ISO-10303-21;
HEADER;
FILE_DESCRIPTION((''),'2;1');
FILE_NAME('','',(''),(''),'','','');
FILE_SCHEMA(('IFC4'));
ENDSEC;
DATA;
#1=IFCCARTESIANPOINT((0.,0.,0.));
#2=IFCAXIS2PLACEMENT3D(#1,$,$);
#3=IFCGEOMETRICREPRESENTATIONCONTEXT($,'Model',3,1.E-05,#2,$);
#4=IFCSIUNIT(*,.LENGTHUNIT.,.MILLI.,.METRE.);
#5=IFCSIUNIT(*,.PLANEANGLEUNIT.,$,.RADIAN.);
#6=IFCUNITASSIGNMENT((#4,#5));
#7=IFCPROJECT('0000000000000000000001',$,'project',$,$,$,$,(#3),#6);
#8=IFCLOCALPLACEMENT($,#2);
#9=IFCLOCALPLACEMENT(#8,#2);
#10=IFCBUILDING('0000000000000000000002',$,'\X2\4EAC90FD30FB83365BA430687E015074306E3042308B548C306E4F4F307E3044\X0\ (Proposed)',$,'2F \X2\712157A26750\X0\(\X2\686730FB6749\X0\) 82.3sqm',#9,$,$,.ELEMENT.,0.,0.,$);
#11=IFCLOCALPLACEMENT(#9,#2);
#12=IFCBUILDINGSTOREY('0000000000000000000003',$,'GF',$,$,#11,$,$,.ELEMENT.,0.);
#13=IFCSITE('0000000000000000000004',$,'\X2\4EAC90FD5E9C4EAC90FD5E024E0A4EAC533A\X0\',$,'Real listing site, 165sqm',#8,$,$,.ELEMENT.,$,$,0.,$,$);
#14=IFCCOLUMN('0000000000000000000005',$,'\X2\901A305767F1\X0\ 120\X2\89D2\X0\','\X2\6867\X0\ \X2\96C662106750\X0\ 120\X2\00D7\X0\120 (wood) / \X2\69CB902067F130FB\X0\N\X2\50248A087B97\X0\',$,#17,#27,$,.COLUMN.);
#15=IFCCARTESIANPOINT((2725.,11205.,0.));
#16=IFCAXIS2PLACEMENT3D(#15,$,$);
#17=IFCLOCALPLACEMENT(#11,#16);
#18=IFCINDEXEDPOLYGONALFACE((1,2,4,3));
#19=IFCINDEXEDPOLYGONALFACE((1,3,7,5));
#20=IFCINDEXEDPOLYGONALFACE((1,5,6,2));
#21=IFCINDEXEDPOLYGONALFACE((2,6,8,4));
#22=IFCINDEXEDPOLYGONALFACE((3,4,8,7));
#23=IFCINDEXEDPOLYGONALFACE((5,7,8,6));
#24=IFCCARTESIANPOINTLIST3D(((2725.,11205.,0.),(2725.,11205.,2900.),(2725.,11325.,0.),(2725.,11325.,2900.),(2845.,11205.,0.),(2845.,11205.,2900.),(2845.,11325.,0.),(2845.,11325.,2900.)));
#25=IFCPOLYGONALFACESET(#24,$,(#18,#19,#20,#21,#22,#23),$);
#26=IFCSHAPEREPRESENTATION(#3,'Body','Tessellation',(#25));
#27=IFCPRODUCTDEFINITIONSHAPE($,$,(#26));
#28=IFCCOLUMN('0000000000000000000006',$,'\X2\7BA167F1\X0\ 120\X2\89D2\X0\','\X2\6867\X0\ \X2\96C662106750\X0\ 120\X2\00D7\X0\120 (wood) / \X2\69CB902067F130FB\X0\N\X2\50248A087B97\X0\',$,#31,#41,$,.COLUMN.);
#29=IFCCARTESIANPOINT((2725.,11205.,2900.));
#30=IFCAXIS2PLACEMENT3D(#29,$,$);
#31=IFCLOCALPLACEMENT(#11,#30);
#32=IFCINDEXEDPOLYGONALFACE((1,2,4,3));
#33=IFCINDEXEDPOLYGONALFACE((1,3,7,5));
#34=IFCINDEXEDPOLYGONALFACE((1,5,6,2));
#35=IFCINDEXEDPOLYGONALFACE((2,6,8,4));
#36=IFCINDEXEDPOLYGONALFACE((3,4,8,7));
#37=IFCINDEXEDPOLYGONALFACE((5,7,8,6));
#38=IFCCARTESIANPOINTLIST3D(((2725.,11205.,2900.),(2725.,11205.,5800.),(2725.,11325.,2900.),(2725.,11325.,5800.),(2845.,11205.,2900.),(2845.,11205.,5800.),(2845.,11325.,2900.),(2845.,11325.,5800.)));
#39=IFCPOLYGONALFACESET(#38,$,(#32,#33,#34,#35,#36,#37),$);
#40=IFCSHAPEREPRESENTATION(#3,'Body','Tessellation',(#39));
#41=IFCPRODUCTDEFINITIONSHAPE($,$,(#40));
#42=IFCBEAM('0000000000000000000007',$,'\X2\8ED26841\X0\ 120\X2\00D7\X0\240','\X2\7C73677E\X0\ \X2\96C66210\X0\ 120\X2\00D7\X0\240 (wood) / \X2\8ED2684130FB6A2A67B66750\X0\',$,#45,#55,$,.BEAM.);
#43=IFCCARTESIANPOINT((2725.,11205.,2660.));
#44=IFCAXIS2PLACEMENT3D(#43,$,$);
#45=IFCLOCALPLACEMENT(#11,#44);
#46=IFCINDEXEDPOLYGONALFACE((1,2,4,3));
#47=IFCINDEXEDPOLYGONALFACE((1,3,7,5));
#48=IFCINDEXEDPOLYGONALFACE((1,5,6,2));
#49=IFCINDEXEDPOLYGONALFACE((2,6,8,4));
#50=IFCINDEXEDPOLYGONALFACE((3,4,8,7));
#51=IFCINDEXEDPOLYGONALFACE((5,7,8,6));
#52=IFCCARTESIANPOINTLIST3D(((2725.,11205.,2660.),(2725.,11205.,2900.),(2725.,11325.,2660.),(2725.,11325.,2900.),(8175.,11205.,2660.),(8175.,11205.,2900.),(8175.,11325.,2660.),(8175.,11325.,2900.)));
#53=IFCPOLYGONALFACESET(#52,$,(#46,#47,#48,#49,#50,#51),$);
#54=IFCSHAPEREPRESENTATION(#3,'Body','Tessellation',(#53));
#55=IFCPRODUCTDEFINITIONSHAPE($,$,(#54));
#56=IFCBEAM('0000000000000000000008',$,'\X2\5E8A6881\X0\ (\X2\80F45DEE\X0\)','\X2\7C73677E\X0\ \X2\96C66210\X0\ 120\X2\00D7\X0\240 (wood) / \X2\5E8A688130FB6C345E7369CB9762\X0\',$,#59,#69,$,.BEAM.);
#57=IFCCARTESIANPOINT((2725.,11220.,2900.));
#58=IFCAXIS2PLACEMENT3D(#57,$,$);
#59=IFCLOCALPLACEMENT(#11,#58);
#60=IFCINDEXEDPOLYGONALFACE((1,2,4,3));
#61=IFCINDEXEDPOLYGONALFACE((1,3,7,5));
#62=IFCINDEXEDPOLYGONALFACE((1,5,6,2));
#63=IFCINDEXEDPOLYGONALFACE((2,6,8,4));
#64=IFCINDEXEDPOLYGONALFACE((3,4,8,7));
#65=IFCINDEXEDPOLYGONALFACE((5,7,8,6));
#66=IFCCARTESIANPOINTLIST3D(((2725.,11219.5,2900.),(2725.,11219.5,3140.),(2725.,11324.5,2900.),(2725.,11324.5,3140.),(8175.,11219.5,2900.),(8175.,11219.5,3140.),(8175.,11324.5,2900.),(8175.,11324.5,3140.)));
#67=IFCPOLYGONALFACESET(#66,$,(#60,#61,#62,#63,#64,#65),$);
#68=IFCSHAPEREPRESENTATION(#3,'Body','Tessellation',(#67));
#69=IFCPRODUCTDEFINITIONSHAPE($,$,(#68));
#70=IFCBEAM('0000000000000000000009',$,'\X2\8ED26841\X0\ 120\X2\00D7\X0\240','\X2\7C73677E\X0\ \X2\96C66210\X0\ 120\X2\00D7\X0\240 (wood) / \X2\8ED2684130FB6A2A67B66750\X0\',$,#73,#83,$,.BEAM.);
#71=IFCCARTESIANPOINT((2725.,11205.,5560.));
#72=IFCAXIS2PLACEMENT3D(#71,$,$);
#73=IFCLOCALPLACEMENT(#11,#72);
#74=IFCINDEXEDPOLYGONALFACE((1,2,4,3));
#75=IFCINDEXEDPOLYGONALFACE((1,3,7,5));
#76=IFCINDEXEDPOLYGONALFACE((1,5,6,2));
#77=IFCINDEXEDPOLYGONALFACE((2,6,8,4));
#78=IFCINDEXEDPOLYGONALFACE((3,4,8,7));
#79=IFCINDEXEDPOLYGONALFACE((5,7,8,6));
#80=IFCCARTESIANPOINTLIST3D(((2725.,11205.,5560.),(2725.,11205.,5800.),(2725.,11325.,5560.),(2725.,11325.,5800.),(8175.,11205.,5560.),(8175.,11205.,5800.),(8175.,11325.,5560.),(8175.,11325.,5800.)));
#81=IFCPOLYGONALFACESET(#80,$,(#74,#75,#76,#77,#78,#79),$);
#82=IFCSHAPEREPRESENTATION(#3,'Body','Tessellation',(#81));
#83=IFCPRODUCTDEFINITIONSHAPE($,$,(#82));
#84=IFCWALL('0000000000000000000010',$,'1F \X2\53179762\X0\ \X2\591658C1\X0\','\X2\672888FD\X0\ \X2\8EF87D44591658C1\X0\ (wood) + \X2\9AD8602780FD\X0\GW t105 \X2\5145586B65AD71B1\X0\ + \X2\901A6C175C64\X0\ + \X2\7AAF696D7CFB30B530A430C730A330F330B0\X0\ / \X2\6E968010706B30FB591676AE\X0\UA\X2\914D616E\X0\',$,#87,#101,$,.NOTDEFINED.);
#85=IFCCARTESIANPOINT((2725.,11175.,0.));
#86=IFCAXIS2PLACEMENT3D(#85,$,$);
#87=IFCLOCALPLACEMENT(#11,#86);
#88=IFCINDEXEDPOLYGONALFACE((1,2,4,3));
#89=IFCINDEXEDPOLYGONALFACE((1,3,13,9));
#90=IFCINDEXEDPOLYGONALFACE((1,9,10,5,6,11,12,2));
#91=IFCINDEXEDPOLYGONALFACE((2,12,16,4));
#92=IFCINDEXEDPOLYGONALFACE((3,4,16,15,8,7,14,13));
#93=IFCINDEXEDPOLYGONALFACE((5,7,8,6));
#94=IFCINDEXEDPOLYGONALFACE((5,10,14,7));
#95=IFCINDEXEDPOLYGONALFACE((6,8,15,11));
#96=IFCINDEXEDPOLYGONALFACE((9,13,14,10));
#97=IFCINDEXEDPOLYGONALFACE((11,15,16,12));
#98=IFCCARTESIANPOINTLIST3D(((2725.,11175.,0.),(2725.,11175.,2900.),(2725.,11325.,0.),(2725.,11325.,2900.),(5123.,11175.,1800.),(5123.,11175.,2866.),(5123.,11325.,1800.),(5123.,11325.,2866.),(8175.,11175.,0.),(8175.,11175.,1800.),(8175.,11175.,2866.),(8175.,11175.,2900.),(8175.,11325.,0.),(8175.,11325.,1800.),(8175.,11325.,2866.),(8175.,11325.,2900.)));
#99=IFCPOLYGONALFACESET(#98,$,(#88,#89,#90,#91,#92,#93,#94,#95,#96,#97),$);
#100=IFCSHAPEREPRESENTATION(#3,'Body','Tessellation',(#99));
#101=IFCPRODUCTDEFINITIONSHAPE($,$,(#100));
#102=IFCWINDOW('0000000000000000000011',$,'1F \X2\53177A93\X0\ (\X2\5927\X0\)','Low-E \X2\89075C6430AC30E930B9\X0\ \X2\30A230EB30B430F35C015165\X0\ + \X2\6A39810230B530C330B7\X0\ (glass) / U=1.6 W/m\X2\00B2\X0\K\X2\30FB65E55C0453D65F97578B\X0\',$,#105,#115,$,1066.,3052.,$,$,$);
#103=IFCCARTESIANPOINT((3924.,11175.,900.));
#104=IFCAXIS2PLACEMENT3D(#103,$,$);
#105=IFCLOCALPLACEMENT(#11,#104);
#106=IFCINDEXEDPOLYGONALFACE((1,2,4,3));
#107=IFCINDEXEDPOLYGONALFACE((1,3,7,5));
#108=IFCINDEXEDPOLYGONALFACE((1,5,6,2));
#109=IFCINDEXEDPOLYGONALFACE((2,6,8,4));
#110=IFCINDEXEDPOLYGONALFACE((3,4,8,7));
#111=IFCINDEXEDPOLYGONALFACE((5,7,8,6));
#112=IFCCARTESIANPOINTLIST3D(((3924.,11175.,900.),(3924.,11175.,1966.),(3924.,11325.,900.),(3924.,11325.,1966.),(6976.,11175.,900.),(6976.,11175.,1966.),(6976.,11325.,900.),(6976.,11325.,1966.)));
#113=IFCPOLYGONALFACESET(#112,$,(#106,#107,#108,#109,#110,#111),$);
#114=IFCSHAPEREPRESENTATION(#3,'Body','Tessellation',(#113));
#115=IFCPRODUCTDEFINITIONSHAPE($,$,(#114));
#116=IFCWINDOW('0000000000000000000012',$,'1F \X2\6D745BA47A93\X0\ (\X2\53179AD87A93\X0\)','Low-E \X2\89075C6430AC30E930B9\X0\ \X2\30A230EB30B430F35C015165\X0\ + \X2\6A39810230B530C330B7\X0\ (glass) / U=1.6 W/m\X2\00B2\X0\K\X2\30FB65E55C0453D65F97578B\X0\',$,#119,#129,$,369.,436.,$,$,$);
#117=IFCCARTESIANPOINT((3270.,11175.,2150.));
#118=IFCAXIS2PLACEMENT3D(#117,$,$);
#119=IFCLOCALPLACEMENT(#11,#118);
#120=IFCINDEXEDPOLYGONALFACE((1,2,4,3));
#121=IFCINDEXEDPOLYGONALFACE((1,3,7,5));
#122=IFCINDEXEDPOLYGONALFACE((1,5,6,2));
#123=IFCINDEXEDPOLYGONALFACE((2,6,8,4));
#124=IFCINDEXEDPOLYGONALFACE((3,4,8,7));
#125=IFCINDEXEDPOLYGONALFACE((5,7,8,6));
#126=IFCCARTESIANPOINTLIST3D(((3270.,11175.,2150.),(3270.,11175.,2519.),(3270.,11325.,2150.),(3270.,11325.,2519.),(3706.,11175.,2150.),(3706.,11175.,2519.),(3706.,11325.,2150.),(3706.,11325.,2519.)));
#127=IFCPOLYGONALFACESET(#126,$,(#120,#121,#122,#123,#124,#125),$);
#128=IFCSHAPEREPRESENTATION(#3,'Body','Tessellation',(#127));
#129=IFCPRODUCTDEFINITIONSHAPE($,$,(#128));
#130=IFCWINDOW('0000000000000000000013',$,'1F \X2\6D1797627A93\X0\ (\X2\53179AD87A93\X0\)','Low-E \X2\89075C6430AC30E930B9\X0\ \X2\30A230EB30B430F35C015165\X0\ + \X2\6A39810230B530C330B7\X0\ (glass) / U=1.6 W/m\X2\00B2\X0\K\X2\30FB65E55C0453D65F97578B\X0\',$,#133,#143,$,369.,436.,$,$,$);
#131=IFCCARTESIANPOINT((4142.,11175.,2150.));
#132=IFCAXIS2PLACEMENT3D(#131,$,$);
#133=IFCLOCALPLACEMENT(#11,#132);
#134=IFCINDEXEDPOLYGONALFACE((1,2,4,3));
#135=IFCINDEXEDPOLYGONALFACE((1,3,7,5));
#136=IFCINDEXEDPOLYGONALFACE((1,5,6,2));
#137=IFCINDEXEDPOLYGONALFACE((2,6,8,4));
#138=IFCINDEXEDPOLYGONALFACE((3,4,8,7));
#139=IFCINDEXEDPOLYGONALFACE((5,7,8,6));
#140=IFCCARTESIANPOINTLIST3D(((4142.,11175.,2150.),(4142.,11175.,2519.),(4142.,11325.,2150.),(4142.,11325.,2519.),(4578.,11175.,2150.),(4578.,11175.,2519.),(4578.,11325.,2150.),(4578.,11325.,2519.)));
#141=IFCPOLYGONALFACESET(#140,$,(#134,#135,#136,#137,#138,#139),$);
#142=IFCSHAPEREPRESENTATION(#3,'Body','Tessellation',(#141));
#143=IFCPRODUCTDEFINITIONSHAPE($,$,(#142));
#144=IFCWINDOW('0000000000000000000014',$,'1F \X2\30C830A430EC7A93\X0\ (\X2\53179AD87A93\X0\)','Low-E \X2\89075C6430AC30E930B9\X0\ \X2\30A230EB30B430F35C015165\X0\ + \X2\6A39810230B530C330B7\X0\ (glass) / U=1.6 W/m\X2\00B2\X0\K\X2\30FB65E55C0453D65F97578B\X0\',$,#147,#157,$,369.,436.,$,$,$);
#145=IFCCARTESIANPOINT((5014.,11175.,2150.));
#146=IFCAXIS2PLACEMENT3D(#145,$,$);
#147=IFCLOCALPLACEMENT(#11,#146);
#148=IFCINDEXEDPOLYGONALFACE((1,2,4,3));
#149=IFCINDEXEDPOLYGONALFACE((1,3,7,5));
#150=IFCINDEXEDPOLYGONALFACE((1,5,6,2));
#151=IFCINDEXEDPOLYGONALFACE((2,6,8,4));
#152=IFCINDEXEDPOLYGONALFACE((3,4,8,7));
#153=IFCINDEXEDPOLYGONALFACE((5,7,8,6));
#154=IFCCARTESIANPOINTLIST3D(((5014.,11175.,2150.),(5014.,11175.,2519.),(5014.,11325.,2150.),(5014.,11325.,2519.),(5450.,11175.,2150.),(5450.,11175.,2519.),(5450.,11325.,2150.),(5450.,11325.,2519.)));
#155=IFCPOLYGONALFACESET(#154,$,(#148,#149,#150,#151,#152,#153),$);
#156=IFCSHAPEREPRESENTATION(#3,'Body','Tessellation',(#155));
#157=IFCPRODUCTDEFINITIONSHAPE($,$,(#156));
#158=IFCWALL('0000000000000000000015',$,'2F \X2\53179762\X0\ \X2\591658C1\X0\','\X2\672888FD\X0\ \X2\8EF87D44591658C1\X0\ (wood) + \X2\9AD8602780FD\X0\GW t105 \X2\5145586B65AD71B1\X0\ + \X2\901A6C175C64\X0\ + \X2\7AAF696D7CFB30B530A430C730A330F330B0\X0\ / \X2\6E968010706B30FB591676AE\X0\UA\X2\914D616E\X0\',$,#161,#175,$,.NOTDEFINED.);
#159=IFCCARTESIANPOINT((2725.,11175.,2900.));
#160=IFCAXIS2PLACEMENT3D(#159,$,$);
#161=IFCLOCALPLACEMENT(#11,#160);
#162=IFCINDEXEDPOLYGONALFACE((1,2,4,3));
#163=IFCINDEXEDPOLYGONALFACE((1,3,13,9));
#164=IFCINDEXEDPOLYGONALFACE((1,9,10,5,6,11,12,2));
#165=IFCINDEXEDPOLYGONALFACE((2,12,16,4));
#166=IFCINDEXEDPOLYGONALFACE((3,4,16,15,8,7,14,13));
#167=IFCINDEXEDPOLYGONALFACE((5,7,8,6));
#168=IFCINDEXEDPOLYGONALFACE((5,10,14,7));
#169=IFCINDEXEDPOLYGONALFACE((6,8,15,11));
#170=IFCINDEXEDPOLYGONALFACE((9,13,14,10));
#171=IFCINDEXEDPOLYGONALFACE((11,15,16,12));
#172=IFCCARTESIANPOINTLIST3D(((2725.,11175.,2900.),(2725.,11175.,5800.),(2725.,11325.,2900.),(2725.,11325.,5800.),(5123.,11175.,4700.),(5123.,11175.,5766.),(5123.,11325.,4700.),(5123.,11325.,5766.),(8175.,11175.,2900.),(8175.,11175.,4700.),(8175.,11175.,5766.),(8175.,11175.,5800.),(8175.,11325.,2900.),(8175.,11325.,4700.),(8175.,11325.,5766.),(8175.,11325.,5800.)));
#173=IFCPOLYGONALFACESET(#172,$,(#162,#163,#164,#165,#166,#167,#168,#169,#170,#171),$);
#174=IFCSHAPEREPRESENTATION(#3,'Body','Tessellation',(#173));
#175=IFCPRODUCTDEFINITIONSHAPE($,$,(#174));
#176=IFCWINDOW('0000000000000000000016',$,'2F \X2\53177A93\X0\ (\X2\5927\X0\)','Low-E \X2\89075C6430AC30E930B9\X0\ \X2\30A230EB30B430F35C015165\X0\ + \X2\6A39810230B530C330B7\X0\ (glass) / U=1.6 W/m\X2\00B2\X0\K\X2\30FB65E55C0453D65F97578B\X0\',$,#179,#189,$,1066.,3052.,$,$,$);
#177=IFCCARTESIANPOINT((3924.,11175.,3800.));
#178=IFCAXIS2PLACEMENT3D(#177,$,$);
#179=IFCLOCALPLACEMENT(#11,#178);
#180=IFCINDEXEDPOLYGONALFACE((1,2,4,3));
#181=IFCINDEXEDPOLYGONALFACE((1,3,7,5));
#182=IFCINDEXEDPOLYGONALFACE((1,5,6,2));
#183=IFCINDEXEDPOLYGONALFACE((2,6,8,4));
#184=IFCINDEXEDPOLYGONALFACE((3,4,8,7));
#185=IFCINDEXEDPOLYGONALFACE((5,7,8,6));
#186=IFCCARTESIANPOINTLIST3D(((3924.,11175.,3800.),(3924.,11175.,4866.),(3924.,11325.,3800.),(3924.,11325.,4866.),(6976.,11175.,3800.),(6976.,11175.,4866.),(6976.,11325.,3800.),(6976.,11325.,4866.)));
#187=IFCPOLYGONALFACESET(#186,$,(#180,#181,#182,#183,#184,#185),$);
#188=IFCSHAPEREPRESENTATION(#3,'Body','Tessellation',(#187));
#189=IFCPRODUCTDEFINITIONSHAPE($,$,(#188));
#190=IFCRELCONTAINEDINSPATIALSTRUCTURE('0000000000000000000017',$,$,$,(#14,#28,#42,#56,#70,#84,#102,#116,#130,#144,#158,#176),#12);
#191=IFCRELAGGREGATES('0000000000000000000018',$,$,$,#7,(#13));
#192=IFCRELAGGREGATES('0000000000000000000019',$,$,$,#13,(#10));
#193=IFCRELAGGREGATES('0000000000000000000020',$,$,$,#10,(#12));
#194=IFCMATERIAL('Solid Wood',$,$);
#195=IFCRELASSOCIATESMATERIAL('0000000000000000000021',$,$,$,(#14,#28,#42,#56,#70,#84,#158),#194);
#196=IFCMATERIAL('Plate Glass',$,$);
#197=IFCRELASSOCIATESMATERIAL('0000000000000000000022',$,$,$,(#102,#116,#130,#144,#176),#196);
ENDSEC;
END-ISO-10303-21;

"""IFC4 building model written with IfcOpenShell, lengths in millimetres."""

from ifc_helpers import new_model, si_unit, frame, frame_2d, origin, place, context, project, spatial, rectangle, extrude, material, element, fill, save


model = new_model("IFC4")

# Units and contexts
model_context = context("Model", 3, precision=1e-05, world=origin())
ifc_project = project(units=[si_unit("LENGTHUNIT", "METRE", prefix="MILLI"), si_unit("PLANEANGLEUNIT", "RADIAN")], contexts=[model_context])

# Site, building, storey
site_placement = place(None, origin())
site = spatial("IfcSite", under=ifc_project, at=site_placement, Name="京都府京都市上京区", ObjectType="Real listing site, 165sqm", CompositionType="ELEMENT", RefElevation=0.0)
building_placement = place(site_placement, origin())
building = spatial("IfcBuilding", under=site, at=building_placement, Name="京都・茶室と縁側のある和の住まい (Proposed)", ObjectType="2F 無垢材(桧・杉) 82.3sqm", CompositionType="ELEMENT", ElevationOfRefHeight=0.0, ElevationOfTerrain=0.0)
storey_placement = place(building_placement, origin())
storey = spatial("IfcBuildingStorey", under=building, at=storey_placement, Name="GF", CompositionType="ELEMENT", Elevation=0.0)

# Columns
ifc_material_1 = material(Name="Solid Wood")
column_1_placement = place(storey_placement, frame((2725.0, 11205.0, 0.0)))
element("IfcColumn", 1, at=column_1_placement, inside=storey, material=ifc_material_1, Name="通し柱 120角", Description="桧 集成材 120×120 (wood) / 構造柱・N値計算", PredefinedType="COLUMN", context=model_context, shape_type="SweptSolid", body=[
    extrude(rectangle(XDim=120.0, YDim=120.0, at=frame_2d((60.0, 60.0))), frame((2725.0, 11205.0, 0.0)), (0.0, 0.0, 1.0), 2900.0),
])
column_2_placement = place(storey_placement, frame((2725.0, 11205.0, 2900.0)))
element("IfcColumn", 2, at=column_2_placement, inside=storey, material=ifc_material_1, Name="管柱 120角", Description="桧 集成材 120×120 (wood) / 構造柱・N値計算", PredefinedType="COLUMN", context=model_context, shape_type="SweptSolid", body=[
    extrude(rectangle(XDim=120.0, YDim=120.0, at=frame_2d((60.0, 60.0))), frame((2725.0, 11205.0, 2900.0)), (0.0, 0.0, 1.0), 2900.0),
])

# Beams
beam_1_placement = place(storey_placement, frame((2725.0, 11205.0, 2660.0)))
element("IfcBeam", 3, at=beam_1_placement, inside=storey, material=ifc_material_1, Name="軒桁 120×240", Description="米松 集成 120×240 (wood) / 軒桁・横架材", PredefinedType="BEAM", context=model_context, shape_type="SweptSolid", body=[
    extrude(rectangle(XDim=5450.0, YDim=120.0, at=frame_2d((2725.0, 60.0))), frame((2725.0, 11205.0, 2660.0)), (0.0, 0.0, 1.0), 240.0),
])
beam_2_placement = place(storey_placement, frame((2725.0, 11220.0, 2900.0)))
element("IfcBeam", 4, at=beam_2_placement, inside=storey, material=ifc_material_1, Name="床梁 (胴差)", Description="米松 集成 120×240 (wood) / 床梁・水平構面", PredefinedType="BEAM", context=model_context, shape_type="SweptSolid", body=[
    extrude(rectangle(XDim=5450.0, YDim=105.0, at=frame_2d((2725.0, 52.0))), frame((2725.0, 11220.0, 2900.0)), (0.0, 0.0, 1.0), 240.0),
])
beam_3_placement = place(storey_placement, frame((2725.0, 11205.0, 5560.0)))
element("IfcBeam", 5, at=beam_3_placement, inside=storey, material=ifc_material_1, Name="軒桁 120×240", Description="米松 集成 120×240 (wood) / 軒桁・横架材", PredefinedType="BEAM", context=model_context, shape_type="SweptSolid", body=[
    extrude(rectangle(XDim=5450.0, YDim=120.0, at=frame_2d((2725.0, 60.0))), frame((2725.0, 11205.0, 5560.0)), (0.0, 0.0, 1.0), 240.0),
])

# Wall, openings, windows
wall_1_placement = place(storey_placement, frame((2725.0, 11175.0, 0.0)))
wall_1 = element("IfcWall", 6, at=wall_1_placement, inside=storey, material=ifc_material_1, Name="1F 北面 外壁", Description="木製 軸組外壁 (wood) + 高性能GW t105 充填断熱 + 通気層 + 窯業系サイディング / 準耐火・外皮UA配慮", PredefinedType="NOTDEFINED", context=model_context, shape_type="SweptSolid", body=[
    extrude(rectangle(XDim=5450.0, YDim=150.0, at=frame_2d((2725.0, 75.0))), frame((2725.0, 11175.0, 0.0)), (0.0, 0.0, 1.0), 2900.0),
])
opening_1_placement = place(storey_placement, frame((3924.0, 11175.0, 900.0)))
opening_1 = element("IfcOpeningElement", 7, at=opening_1_placement, cuts=wall_1, PredefinedType="NOTDEFINED", context=model_context, shape_type="SweptSolid", body=[
    extrude(rectangle(XDim=3052.0, YDim=150.0, at=frame_2d((1526.0, 75.0))), frame((3924.0, 11175.0, 900.0)), (0.0, 0.0, 1.0), 1066.0),
])
opening_2_placement = place(storey_placement, frame((3270.0, 11175.0, 2150.0)))
opening_2 = element("IfcOpeningElement", 8, at=opening_2_placement, cuts=wall_1, PredefinedType="NOTDEFINED", context=model_context, shape_type="SweptSolid", body=[
    extrude(rectangle(XDim=436.0, YDim=150.0, at=frame_2d((218.0, 75.0))), frame((3270.0, 11175.0, 2150.0)), (0.0, 0.0, 1.0), 369.0),
])
opening_3_placement = place(storey_placement, frame((4142.0, 11175.0, 2150.0)))
opening_3 = element("IfcOpeningElement", 9, at=opening_3_placement, cuts=wall_1, PredefinedType="NOTDEFINED", context=model_context, shape_type="SweptSolid", body=[
    extrude(rectangle(XDim=436.0, YDim=150.0, at=frame_2d((218.0, 75.0))), frame((4142.0, 11175.0, 2150.0)), (0.0, 0.0, 1.0), 369.0),
])
opening_4_placement = place(storey_placement, frame((5014.0, 11175.0, 2150.0)))
opening_4 = element("IfcOpeningElement", 10, at=opening_4_placement, cuts=wall_1, PredefinedType="NOTDEFINED", context=model_context, shape_type="SweptSolid", body=[
    extrude(rectangle(XDim=436.0, YDim=150.0, at=frame_2d((218.0, 75.0))), frame((5014.0, 11175.0, 2150.0)), (0.0, 0.0, 1.0), 369.0),
])
ifc_material_2 = material(Name="Plate Glass")
window_1_placement = place(storey_placement, frame((3924.0, 11175.0, 900.0)))
window_1 = element("IfcWindow", 11, at=window_1_placement, inside=storey, material=ifc_material_2, Name="1F 北窓 (大)", Description="Low-E 複層ガラス アルゴン封入 + 樹脂サッシ (glass) / U=1.6 W/m²K・日射取得型", OverallHeight=1066.0, OverallWidth=3052.0, context=model_context, shape_type="SweptSolid", body=[
    extrude(rectangle(XDim=3052.0, YDim=150.0, at=frame_2d((1526.0, 75.0))), frame((3924.0, 11175.0, 900.0)), (0.0, 0.0, 1.0), 1066.0),
])
fill(opening_1, window_1)
window_2_placement = place(storey_placement, frame((3270.0, 11175.0, 2150.0)))
window_2 = element("IfcWindow", 12, at=window_2_placement, inside=storey, material=ifc_material_2, Name="1F 浴室窓 (北高窓)", Description="Low-E 複層ガラス アルゴン封入 + 樹脂サッシ (glass) / U=1.6 W/m²K・日射取得型", OverallHeight=369.0, OverallWidth=436.0, context=model_context, shape_type="SweptSolid", body=[
    extrude(rectangle(XDim=436.0, YDim=150.0, at=frame_2d((218.0, 75.0))), frame((3270.0, 11175.0, 2150.0)), (0.0, 0.0, 1.0), 369.0),
])
fill(opening_2, window_2)
window_3_placement = place(storey_placement, frame((4142.0, 11175.0, 2150.0)))
window_3 = element("IfcWindow", 13, at=window_3_placement, inside=storey, material=ifc_material_2, Name="1F 洗面窓 (北高窓)", Description="Low-E 複層ガラス アルゴン封入 + 樹脂サッシ (glass) / U=1.6 W/m²K・日射取得型", OverallHeight=369.0, OverallWidth=436.0, context=model_context, shape_type="SweptSolid", body=[
    extrude(rectangle(XDim=436.0, YDim=150.0, at=frame_2d((218.0, 75.0))), frame((4142.0, 11175.0, 2150.0)), (0.0, 0.0, 1.0), 369.0),
])
fill(opening_3, window_3)
window_4_placement = place(storey_placement, frame((5014.0, 11175.0, 2150.0)))
window_4 = element("IfcWindow", 14, at=window_4_placement, inside=storey, material=ifc_material_2, Name="1F トイレ窓 (北高窓)", Description="Low-E 複層ガラス アルゴン封入 + 樹脂サッシ (glass) / U=1.6 W/m²K・日射取得型", OverallHeight=369.0, OverallWidth=436.0, context=model_context, shape_type="SweptSolid", body=[
    extrude(rectangle(XDim=436.0, YDim=150.0, at=frame_2d((218.0, 75.0))), frame((5014.0, 11175.0, 2150.0)), (0.0, 0.0, 1.0), 369.0),
])
fill(opening_4, window_4)

# Wall, opening, window
wall_2_placement = place(storey_placement, frame((2725.0, 11175.0, 2900.0)))
wall_2 = element("IfcWall", 15, at=wall_2_placement, inside=storey, material=ifc_material_1, Name="2F 北面 外壁", Description="木製 軸組外壁 (wood) + 高性能GW t105 充填断熱 + 通気層 + 窯業系サイディング / 準耐火・外皮UA配慮", PredefinedType="NOTDEFINED", context=model_context, shape_type="SweptSolid", body=[
    extrude(rectangle(XDim=5450.0, YDim=150.0, at=frame_2d((2725.0, 75.0))), frame((2725.0, 11175.0, 2900.0)), (0.0, 0.0, 1.0), 2900.0),
])
opening_5_placement = place(storey_placement, frame((3924.0, 11175.0, 3800.0)))
opening_5 = element("IfcOpeningElement", 16, at=opening_5_placement, cuts=wall_2, PredefinedType="NOTDEFINED", context=model_context, shape_type="SweptSolid", body=[
    extrude(rectangle(XDim=3052.0, YDim=150.0, at=frame_2d((1526.0, 75.0))), frame((3924.0, 11175.0, 3800.0)), (0.0, 0.0, 1.0), 1066.0),
])
window_5_placement = place(storey_placement, frame((3924.0, 11175.0, 3800.0)))
window_5 = element("IfcWindow", 17, at=window_5_placement, inside=storey, material=ifc_material_2, Name="2F 北窓 (大)", Description="Low-E 複層ガラス アルゴン封入 + 樹脂サッシ (glass) / U=1.6 W/m²K・日射取得型", OverallHeight=1066.0, OverallWidth=3052.0, context=model_context, shape_type="SweptSolid", body=[
    extrude(rectangle(XDim=3052.0, YDim=150.0, at=frame_2d((1526.0, 75.0))), frame((3924.0, 11175.0, 3800.0)), (0.0, 0.0, 1.0), 1066.0),
])
fill(opening_5, window_5)

save(model, "model.ifc")
